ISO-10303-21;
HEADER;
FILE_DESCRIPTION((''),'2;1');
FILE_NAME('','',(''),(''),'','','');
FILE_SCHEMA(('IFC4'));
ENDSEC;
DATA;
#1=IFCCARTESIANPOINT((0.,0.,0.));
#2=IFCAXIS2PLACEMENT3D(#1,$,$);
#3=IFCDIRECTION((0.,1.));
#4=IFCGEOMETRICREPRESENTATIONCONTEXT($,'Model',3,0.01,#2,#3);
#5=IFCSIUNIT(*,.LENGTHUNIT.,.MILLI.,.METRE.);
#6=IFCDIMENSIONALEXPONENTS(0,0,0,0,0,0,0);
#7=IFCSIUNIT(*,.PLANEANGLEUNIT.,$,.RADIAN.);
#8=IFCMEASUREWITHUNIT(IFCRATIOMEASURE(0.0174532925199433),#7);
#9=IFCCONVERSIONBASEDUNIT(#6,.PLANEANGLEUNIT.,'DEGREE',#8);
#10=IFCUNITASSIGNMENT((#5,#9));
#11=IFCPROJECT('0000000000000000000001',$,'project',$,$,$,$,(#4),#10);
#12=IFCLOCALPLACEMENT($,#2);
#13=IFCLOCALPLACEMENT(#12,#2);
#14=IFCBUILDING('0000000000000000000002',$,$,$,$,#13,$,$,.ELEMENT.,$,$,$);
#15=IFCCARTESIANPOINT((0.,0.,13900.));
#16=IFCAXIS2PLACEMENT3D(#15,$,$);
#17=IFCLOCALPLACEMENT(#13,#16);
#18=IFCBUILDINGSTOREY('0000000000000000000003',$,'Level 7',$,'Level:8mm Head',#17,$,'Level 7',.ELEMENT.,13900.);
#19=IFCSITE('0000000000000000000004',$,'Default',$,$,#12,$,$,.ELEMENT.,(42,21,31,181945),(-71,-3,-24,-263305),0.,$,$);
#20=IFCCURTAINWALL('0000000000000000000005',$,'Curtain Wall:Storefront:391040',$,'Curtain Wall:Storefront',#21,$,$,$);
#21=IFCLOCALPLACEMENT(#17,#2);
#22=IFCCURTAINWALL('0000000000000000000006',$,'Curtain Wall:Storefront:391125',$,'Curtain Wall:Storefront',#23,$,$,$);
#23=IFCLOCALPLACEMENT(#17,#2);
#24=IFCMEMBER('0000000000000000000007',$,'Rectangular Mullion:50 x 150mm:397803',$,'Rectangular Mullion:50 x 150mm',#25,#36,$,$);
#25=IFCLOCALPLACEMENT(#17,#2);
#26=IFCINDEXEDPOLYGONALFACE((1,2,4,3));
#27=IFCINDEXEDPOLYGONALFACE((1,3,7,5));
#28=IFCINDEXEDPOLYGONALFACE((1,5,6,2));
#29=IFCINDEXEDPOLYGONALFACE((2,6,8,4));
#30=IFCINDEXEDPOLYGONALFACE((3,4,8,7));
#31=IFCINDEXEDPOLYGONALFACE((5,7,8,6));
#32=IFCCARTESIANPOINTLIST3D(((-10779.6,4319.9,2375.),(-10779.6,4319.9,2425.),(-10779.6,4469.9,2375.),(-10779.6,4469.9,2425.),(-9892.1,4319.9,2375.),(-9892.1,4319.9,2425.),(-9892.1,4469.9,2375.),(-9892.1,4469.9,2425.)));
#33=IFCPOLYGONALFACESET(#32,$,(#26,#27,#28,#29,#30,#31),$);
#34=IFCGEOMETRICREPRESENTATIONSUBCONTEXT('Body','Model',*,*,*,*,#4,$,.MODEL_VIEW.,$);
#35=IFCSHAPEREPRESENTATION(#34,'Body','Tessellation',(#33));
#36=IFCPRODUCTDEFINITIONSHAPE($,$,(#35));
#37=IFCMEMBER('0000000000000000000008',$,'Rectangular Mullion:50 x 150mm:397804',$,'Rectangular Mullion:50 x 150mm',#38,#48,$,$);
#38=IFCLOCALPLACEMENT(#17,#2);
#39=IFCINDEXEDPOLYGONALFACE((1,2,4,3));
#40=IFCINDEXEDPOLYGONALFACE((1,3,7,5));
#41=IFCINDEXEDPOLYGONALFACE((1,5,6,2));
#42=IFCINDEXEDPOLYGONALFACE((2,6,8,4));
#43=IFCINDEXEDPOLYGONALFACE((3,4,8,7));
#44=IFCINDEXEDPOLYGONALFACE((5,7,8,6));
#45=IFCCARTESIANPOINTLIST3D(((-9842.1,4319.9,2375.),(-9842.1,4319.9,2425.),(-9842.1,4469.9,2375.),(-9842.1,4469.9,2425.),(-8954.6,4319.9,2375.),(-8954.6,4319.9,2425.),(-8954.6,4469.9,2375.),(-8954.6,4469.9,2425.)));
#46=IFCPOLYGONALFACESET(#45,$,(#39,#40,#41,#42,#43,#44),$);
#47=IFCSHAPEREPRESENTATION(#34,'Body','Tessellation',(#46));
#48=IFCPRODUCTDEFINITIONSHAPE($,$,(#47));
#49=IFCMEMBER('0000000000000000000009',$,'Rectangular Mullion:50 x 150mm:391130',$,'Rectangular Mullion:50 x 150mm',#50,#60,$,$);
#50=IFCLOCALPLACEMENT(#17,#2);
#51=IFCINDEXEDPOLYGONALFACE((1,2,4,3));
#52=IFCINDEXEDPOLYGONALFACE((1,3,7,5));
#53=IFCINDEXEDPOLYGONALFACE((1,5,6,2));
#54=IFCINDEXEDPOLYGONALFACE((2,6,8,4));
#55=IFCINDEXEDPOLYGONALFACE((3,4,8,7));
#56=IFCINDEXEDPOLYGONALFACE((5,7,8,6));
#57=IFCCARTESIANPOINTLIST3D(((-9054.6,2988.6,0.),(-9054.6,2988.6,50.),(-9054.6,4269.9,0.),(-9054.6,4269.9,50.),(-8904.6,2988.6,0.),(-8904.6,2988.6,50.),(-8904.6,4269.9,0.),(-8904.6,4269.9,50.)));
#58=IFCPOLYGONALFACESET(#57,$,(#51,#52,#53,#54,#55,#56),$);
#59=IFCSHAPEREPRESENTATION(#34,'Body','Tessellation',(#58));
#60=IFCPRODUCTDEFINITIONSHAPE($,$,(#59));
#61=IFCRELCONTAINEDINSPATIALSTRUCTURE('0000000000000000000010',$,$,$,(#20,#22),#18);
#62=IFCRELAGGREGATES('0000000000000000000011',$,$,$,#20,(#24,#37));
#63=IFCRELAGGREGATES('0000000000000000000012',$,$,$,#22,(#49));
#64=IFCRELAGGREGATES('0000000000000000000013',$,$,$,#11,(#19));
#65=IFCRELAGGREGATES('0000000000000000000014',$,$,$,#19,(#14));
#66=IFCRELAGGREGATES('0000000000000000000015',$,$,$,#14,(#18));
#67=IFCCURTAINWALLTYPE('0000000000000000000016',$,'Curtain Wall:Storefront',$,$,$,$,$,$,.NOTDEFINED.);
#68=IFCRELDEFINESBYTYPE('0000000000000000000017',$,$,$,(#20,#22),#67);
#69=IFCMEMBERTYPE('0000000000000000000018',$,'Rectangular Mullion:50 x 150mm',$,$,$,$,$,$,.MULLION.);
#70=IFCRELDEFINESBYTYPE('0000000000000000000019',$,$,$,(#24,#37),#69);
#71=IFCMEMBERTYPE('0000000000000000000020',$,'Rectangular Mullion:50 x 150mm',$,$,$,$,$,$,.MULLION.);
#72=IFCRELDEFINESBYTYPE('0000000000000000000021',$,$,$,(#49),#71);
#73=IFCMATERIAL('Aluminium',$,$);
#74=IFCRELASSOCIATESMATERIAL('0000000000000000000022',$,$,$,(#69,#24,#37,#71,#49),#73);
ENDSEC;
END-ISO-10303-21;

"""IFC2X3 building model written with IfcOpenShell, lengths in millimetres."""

from ifc_helpers import new_model, entity, si_unit, converted_unit, direction, frame, origin, origin_2d_with_axis, place, context, subcontext, project, spatial, rectangle, extrude, source, transform, mapped, material, type_object, type_shapes, element, aggregate, save


model = new_model("IFC2X3")

# Units and contexts
model_context = context("Model", 3, precision=0.01, world=origin(), true_north=direction((0.0, 1.0)))
body_context = subcontext(model_context, "Body", "Model", "MODEL_VIEW")
ifc_project = project(units=[si_unit("LENGTHUNIT", "METRE", prefix="MILLI"), converted_unit("PLANEANGLEUNIT", "DEGREE", entity("IfcRatioMeasure", 0.0174532925199433), si_unit("PLANEANGLEUNIT", "RADIAN"), dimensions=[0, 0, 0, 0, 0, 0, 0])], contexts=[model_context])

# Site, building, storey
site_placement = place(None, frame((0.0, 0.0, 0.0)))
site = spatial("IfcSite", under=ifc_project, at=site_placement, Name="Default", CompositionType="ELEMENT", RefLatitude=(42, 21, 31, 181945), RefLongitude=(-71, -3, -24, -263305), RefElevation=0.0)
building_placement = place(site_placement, origin())
building = spatial("IfcBuilding", under=site, at=building_placement, CompositionType="ELEMENT")
storey_placement = place(building_placement, frame((0.0, 0.0, 13900.0)))
storey = spatial("IfcBuildingStorey", under=building, at=storey_placement, Name="Level 7", ObjectType="Level:8mm Head", LongName="Level 7", CompositionType="ELEMENT", Elevation=13900.0)

# Shared definitions
curtain_wall_type = type_object("IfcCurtainWallType", Name="Curtain Wall:Storefront", PredefinedType="NOTDEFINED")
ifc_material_1 = material(Name="Aluminium")

# Curtain wall
curtain_wall_1_placement = place(storey_placement, frame((0.0, 0.0, -13900.0)))
curtain_wall_1 = element("IfcCurtainWall", 1, at=curtain_wall_1_placement, inside=storey, type_object=curtain_wall_type, Name="Curtain Wall:Storefront:391040", ObjectType="Curtain Wall:Storefront")

# Curtain wall
curtain_wall_2_placement = place(storey_placement, frame((0.0, 0.0, -13900.0)))
curtain_wall_2 = element("IfcCurtainWall", 2, at=curtain_wall_2_placement, inside=storey, type_object=curtain_wall_type, Name="Curtain Wall:Storefront:391125", ObjectType="Curtain Wall:Storefront")

# Members
member_type_1 = type_object("IfcMemberType", Name="Rectangular Mullion:50 x 150mm", PredefinedType="MULLION", material=ifc_material_1)
shared_shape_1 = source(origin(), body_context, "Body", "SweptSolid", [
    extrude(rectangle(XDim=150.0, YDim=50.0, at=origin_2d_with_axis()), frame((0.0, 0.0, -887.5), z_axis=(0.0, 0.0, 1.0), x_axis=(0.0, -1.0, 0.0)), (0.0, 0.0, 1.0), 887.5),
])
type_shapes(member_type_1, [shared_shape_1])
member_1_placement = place(storey_placement, frame((-9892.1, 4394.9, 2400.0), z_axis=(1.0, 0.0, 0.0), x_axis=(0.0, 0.0, 1.0)))
member_1 = element("IfcMember", 3, at=member_1_placement, type_object=member_type_1, material=ifc_material_1, Name="Rectangular Mullion:50 x 150mm:397803", ObjectType="Rectangular Mullion:50 x 150mm", context=body_context, shape_type="MappedRepresentation", body=[
    mapped(shared_shape_1, transform((0.0, 0.0, 0.0), scale=1.0)),
])
member_2_placement = place(storey_placement, frame((-8954.6, 4394.9, 2400.0), z_axis=(1.0, 0.0, 0.0), x_axis=(0.0, 0.0, 1.0)))
member_2 = element("IfcMember", 4, at=member_2_placement, type_object=member_type_1, material=ifc_material_1, Name="Rectangular Mullion:50 x 150mm:397804", ObjectType="Rectangular Mullion:50 x 150mm", context=body_context, shape_type="MappedRepresentation", body=[
    mapped(shared_shape_1, transform((0.0, 0.0, 0.0), scale=1.0)),
])
member_type_2 = type_object("IfcMemberType", Name="Rectangular Mullion:50 x 150mm", PredefinedType="MULLION", material=ifc_material_1)
shared_shape_2 = source(origin(), body_context, "Body", "SweptSolid", [
    extrude(rectangle(XDim=150.0, YDim=50.0, at=origin_2d_with_axis()), frame((-25.0, 0.0, -1281.3), z_axis=(0.0, 0.0, 1.0), x_axis=(0.0, -1.0, 0.0)), (0.0, 0.0, 1.0), 1281.3),
])
type_shapes(member_type_2, [shared_shape_2])
member_3_placement = place(building_placement, frame((-8979.6, 4269.9, 13900.0), z_axis=(0.0, 1.0, 0.0), x_axis=(0.0, 0.0, -1.0)))
member_3 = element("IfcMember", 5, at=member_3_placement, type_object=member_type_2, material=ifc_material_1, Name="Rectangular Mullion:50 x 150mm:391130", ObjectType="Rectangular Mullion:50 x 150mm", context=body_context, shape_type="MappedRepresentation", body=[
    mapped(shared_shape_2, transform((0.0, 0.0, 0.0), scale=1.0)),
])

aggregate(curtain_wall_1, [member_1, member_2])
aggregate(curtain_wall_2, [member_3])

save(model, "model.ifc")
